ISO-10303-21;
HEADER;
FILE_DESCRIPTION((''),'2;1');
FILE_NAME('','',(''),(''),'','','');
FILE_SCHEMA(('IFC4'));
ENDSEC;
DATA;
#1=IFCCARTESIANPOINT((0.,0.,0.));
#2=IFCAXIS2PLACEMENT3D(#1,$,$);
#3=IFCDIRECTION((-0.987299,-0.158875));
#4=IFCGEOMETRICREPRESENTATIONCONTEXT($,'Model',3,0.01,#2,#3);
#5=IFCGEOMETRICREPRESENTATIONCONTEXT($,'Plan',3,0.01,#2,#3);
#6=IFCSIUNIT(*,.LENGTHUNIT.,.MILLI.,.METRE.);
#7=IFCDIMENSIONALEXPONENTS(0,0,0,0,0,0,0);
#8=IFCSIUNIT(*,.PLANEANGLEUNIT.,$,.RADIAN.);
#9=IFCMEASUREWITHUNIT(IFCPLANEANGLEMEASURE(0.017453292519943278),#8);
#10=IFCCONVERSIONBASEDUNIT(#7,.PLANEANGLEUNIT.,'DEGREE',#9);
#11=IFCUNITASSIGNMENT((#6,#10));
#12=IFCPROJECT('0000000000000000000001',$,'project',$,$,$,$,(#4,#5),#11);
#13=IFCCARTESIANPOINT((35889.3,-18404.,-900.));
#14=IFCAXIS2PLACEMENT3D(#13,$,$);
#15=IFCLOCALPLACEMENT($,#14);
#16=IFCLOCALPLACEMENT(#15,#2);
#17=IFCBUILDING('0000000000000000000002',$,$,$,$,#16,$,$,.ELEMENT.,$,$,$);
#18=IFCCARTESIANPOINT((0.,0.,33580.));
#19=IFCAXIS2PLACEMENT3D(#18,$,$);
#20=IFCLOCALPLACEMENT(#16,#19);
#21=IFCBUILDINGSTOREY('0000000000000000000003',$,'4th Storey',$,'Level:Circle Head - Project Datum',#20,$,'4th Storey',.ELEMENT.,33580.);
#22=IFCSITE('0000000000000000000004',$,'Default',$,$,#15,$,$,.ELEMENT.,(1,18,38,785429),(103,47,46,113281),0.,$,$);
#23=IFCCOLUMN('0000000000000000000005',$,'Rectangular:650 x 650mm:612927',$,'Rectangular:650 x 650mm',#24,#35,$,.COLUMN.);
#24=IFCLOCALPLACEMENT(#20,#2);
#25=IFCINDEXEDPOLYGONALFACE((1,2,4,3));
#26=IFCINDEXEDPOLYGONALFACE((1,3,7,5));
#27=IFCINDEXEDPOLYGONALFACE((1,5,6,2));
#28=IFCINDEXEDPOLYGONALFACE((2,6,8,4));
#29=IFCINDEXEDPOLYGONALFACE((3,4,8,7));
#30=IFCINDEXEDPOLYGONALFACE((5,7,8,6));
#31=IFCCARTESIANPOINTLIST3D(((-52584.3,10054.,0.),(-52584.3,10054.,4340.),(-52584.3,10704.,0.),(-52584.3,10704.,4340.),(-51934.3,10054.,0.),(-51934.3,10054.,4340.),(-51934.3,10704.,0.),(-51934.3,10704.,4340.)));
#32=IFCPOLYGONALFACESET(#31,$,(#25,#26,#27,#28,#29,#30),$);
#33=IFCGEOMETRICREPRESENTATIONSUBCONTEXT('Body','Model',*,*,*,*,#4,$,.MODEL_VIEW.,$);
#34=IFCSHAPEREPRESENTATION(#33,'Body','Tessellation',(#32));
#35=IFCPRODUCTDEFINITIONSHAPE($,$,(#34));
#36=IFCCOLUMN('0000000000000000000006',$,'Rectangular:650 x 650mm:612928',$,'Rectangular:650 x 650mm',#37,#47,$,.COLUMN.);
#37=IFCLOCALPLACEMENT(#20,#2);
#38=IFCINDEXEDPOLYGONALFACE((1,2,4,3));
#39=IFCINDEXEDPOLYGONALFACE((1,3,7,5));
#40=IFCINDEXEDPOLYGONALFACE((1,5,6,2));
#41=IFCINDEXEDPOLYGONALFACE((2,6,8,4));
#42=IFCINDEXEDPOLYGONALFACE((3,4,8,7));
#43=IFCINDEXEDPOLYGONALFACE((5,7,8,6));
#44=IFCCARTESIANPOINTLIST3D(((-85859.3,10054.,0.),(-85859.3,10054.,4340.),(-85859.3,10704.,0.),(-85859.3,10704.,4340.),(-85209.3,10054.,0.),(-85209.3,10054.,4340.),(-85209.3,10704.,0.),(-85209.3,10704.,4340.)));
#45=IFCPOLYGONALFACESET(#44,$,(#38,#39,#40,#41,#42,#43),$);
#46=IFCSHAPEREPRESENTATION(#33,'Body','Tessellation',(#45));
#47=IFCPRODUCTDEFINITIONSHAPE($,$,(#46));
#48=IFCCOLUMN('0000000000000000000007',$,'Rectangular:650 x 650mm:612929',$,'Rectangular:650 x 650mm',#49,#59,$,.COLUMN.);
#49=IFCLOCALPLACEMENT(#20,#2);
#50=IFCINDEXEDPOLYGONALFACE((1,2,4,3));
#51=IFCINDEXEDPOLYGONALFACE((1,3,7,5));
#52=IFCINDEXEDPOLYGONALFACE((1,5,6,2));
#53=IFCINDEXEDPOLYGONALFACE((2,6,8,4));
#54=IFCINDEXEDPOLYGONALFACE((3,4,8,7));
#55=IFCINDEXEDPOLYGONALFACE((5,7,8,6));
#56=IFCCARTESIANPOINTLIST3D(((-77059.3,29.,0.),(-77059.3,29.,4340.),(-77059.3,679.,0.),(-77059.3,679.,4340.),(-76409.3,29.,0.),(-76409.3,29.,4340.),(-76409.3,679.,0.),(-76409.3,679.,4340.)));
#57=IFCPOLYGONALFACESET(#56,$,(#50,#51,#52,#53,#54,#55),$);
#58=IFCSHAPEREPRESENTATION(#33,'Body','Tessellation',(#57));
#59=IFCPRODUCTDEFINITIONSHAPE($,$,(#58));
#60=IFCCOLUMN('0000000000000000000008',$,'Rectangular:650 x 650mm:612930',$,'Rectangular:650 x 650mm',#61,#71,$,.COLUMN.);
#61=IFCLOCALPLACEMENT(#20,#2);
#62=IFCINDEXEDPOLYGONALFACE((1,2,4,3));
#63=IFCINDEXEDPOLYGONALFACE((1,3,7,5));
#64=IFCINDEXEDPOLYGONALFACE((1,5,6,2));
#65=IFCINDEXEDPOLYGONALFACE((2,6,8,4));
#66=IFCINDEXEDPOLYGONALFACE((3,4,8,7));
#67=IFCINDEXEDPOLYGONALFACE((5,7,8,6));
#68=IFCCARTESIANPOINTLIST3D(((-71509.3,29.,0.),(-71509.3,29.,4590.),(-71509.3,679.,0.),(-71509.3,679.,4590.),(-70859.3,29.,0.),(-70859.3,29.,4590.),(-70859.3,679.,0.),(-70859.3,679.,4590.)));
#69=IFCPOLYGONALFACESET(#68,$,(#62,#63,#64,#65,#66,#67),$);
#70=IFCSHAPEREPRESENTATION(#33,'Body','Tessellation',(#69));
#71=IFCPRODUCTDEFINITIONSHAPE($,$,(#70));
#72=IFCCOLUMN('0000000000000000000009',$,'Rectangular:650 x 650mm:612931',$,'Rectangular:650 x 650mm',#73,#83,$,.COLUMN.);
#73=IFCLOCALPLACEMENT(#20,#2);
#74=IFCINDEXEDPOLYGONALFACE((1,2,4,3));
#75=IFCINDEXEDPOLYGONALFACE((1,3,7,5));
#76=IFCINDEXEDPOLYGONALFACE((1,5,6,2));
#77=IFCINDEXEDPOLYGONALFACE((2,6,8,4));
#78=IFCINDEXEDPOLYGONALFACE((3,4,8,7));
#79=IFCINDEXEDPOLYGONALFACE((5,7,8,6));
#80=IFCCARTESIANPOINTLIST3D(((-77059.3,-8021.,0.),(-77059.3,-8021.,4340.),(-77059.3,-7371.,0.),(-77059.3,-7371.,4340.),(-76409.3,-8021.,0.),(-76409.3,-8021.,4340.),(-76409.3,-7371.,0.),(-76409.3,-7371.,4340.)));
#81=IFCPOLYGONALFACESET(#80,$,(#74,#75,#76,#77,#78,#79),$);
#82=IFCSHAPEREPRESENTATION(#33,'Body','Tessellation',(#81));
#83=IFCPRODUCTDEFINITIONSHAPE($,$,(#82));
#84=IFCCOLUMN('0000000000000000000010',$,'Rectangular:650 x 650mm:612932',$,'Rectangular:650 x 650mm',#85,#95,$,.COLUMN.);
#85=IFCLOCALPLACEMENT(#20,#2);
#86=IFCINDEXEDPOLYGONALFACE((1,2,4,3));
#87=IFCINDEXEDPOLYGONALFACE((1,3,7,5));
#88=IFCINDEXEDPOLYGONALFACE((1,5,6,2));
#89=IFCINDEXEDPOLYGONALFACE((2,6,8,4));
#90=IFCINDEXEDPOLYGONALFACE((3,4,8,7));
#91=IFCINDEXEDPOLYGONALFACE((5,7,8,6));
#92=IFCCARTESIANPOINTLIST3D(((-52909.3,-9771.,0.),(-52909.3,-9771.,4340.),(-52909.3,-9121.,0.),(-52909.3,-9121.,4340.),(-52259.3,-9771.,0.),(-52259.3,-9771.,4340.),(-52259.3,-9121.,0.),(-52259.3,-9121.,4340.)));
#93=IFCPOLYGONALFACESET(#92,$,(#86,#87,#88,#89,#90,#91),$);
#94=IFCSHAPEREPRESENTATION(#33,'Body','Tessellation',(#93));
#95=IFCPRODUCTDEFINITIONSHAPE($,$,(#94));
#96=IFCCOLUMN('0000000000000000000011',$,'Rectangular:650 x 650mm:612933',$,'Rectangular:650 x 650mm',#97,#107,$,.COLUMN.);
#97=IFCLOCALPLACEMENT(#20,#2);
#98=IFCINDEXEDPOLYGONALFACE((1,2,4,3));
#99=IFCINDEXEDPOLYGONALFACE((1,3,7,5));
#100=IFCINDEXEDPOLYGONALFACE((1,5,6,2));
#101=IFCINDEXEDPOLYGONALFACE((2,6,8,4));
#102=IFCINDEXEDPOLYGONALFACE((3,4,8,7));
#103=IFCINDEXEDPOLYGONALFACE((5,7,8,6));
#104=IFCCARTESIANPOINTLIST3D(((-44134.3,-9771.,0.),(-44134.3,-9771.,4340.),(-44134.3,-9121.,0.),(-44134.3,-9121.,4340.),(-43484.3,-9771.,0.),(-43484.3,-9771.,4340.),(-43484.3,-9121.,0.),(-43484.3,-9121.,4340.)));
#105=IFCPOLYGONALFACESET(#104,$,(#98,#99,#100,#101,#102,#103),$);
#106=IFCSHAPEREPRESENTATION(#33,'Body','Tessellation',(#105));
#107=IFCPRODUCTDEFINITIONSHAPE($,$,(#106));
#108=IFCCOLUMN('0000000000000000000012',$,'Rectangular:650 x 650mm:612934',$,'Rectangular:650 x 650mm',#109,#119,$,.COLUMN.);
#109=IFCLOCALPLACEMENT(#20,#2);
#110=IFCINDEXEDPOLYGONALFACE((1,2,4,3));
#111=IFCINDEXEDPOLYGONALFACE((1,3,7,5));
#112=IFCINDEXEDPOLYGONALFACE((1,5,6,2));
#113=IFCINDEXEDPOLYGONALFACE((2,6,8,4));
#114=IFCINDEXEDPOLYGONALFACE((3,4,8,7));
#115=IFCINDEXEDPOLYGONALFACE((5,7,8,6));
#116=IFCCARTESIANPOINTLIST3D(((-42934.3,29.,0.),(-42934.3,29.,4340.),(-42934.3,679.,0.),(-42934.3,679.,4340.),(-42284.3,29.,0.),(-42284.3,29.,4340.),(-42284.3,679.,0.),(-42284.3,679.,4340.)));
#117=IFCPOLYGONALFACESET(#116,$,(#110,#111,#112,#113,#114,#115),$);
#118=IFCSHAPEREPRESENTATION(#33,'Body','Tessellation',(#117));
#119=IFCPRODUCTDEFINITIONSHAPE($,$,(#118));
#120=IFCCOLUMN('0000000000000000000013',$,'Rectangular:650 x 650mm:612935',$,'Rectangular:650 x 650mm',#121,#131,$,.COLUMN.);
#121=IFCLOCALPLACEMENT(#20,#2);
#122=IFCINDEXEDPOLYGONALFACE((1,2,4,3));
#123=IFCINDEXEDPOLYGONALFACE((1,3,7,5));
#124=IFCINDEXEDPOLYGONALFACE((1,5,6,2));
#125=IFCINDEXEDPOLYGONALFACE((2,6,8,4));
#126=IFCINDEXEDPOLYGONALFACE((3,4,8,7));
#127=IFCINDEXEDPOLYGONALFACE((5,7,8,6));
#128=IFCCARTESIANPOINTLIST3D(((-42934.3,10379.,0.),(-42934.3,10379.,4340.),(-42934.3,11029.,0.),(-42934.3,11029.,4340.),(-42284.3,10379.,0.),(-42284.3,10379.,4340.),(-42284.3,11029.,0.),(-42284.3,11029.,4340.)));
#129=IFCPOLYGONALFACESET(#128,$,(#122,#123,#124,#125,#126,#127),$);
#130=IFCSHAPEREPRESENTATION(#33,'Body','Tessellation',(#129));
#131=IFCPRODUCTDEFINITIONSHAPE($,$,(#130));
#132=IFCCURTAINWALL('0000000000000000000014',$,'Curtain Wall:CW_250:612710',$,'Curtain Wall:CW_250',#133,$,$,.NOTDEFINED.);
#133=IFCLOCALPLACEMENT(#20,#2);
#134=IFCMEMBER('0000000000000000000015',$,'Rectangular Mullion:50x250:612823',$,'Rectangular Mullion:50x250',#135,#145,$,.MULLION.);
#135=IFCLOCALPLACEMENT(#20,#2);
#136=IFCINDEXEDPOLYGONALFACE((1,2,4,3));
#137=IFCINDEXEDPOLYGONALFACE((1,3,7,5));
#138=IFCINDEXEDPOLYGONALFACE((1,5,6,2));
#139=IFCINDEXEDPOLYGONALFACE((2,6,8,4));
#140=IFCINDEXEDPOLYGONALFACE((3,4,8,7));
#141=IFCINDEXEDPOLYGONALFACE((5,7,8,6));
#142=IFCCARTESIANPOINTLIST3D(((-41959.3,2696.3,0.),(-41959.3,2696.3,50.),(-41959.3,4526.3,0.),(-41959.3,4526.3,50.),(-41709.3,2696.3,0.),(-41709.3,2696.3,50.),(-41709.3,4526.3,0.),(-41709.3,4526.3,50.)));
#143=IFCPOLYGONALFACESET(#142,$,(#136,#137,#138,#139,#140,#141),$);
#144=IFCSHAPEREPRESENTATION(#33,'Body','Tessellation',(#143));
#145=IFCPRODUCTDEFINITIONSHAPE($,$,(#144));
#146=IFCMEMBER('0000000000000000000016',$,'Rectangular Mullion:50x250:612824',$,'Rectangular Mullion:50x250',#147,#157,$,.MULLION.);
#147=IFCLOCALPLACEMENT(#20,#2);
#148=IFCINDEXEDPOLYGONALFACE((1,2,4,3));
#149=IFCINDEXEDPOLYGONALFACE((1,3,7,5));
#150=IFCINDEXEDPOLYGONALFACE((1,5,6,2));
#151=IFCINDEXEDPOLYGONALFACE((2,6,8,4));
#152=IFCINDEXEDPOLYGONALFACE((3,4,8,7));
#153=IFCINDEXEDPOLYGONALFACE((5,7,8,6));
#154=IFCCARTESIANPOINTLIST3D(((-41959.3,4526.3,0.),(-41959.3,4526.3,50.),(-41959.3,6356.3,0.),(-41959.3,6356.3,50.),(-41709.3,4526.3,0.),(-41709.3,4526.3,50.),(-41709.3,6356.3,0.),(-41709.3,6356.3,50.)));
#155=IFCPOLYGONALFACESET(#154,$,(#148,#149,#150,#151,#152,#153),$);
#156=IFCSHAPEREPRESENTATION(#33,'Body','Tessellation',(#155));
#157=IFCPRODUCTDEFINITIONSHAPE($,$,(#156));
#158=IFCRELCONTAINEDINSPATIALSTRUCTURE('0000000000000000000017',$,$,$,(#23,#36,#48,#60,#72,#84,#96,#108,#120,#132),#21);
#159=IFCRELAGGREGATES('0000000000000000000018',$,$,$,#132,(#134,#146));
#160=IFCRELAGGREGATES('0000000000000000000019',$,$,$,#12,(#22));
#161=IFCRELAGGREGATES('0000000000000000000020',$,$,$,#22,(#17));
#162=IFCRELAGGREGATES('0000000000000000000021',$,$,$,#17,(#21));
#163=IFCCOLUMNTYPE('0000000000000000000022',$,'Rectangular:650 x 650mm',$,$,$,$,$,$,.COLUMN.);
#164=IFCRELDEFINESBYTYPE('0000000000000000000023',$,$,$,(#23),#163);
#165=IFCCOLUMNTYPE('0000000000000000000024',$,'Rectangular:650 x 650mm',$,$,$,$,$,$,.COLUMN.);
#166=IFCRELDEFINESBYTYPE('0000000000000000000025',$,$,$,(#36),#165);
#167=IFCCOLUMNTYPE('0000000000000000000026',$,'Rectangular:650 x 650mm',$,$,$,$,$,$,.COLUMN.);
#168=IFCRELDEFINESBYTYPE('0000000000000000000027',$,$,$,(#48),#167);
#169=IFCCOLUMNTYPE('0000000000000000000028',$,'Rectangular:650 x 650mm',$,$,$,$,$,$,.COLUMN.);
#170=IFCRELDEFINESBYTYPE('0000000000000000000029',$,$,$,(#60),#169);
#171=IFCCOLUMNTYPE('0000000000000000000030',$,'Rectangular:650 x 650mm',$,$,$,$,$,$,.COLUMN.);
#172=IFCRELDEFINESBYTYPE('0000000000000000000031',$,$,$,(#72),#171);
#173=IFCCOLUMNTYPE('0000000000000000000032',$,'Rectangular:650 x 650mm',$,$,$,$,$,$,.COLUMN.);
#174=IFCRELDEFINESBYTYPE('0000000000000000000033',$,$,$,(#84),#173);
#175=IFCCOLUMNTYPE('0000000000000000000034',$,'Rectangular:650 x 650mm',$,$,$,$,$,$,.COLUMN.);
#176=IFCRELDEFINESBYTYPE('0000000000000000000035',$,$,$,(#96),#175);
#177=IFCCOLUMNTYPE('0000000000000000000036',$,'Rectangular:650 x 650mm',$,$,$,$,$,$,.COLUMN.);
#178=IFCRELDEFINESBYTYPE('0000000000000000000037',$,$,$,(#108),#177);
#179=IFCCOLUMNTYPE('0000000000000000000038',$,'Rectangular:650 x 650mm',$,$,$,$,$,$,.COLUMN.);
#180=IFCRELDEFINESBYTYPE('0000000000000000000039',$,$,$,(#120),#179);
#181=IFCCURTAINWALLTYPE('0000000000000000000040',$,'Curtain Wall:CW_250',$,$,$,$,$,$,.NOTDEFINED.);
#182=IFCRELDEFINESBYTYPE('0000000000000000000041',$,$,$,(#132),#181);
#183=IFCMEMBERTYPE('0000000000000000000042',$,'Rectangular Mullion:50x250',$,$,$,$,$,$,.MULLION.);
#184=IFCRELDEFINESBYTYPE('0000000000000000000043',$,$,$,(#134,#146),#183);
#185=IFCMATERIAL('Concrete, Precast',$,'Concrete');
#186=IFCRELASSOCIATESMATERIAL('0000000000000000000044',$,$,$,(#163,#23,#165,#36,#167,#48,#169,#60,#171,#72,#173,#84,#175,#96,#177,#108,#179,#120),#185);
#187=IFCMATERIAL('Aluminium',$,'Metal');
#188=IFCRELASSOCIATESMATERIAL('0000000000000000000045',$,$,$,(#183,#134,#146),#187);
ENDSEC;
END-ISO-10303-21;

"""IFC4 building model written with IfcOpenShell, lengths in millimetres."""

from ifc_helpers import new_model, entity, si_unit, converted_unit, direction, frame, origin, place, context, subcontext, project, spatial, indexed_curve, outline, extrude, source, transform, mapped, material, type_object, type_shapes, element, aggregate, save


model = new_model("IFC4")

# Units and contexts
model_context = context("Model", 3, precision=0.01, world=origin(), true_north=direction((-0.987299, -0.158875)))
plan_context = context("Plan", 3, precision=0.01, world=origin(), true_north=direction((-0.987299, -0.158875)))
body_context = subcontext(model_context, "Body", "Model", "MODEL_VIEW")
ifc_project = project(units=[si_unit("LENGTHUNIT", "METRE", prefix="MILLI"), converted_unit("PLANEANGLEUNIT", "DEGREE", entity("IfcPlaneAngleMeasure", 0.017453292519943278), si_unit("PLANEANGLEUNIT", "RADIAN"), dimensions=[0, 0, 0, 0, 0, 0, 0])], contexts=[model_context, plan_context])

# Site, building, storey
site_placement = place(None, frame((35889.3, -18404.0, -900.0)))
site = spatial("IfcSite", under=ifc_project, at=site_placement, Name="Default", CompositionType="ELEMENT", RefLatitude=(1, 18, 38, 785429), RefLongitude=(103, 47, 46, 113281), RefElevation=0.0)
building_placement = place(site_placement, origin())
building = spatial("IfcBuilding", under=site, at=building_placement, CompositionType="ELEMENT")
storey_placement = place(building_placement, frame((0.0, 0.0, 33580.0)))
storey = spatial("IfcBuildingStorey", under=building, at=storey_placement, Name="4th Storey", ObjectType="Level:Circle Head - Project Datum", LongName="4th Storey", CompositionType="ELEMENT", Elevation=33580.0)

# Columns
ifc_material_1 = material(Name="Concrete, Precast", Category="Concrete")
column_type_1 = type_object("IfcColumnType", Name="Rectangular:650 x 650mm", PredefinedType="COLUMN", material=ifc_material_1)
shared_shape_1 = source(origin(), body_context, "Body", "SweptSolid", [
    extrude(outline(indexed_curve([(-325.0, -325.0), (325.0, -325.0), (325.0, 325.0), (-325.0, 325.0), (-325.0, -325.0)], self_intersect=False)), frame((-52259.3, 10379.0, 33580.0), z_axis=(0.0, 0.0, 1.0), x_axis=(0.0, -1.0, 0.0)), (0.0, 0.0, 1.0), 4340.0),
])
type_shapes(column_type_1, [shared_shape_1])
column_1_placement = place(storey_placement, frame((0.0, 0.0, -33580.0)))
element("IfcColumn", 1, at=column_1_placement, inside=storey, type_object=column_type_1, material=ifc_material_1, Name="Rectangular:650 x 650mm:612927", ObjectType="Rectangular:650 x 650mm", PredefinedType="COLUMN", context=body_context, shape_type="MappedRepresentation", body=[
    mapped(shared_shape_1, transform((0.0, 0.0, 0.0), scale=1.0)),
])
column_type_2 = type_object("IfcColumnType", Name="Rectangular:650 x 650mm", PredefinedType="COLUMN", material=ifc_material_1)
shared_shape_2 = source(origin(), body_context, "Body", "SweptSolid", [
    extrude(outline(indexed_curve([(-325.0, -325.0), (325.0, -325.0), (325.0, 325.0), (-325.0, 325.0), (-325.0, -325.0)], self_intersect=False)), frame((-85534.3, 10379.0, 33580.0), z_axis=(0.0, 0.0, 1.0), x_axis=(0.0, 1.0, 0.0)), (0.0, 0.0, 1.0), 4340.0),
])
type_shapes(column_type_2, [shared_shape_2])
column_2_placement = place(storey_placement, frame((0.0, 0.0, -33580.0)))
element("IfcColumn", 2, at=column_2_placement, inside=storey, type_object=column_type_2, material=ifc_material_1, Name="Rectangular:650 x 650mm:612928", ObjectType="Rectangular:650 x 650mm", PredefinedType="COLUMN", context=body_context, shape_type="MappedRepresentation", body=[
    mapped(shared_shape_2, transform((0.0, 0.0, 0.0), scale=1.0)),
])
column_type_3 = type_object("IfcColumnType", Name="Rectangular:650 x 650mm", PredefinedType="COLUMN", material=ifc_material_1)
shared_shape_3 = source(origin(), body_context, "Body", "SweptSolid", [
    extrude(outline(indexed_curve([(-325.0, -325.0), (325.0, -325.0), (325.0, 325.0), (-325.0, 325.0), (-325.0, -325.0)], self_intersect=False)), frame((-76734.3, 354.0, 33580.0), z_axis=(0.0, 0.0, 1.0), x_axis=(-1.0, 0.0, 0.0)), (0.0, 0.0, 1.0), 4340.0),
])
type_shapes(column_type_3, [shared_shape_3])
column_3_placement = place(storey_placement, frame((0.0, 0.0, -33580.0)))
element("IfcColumn", 3, at=column_3_placement, inside=storey, type_object=column_type_3, material=ifc_material_1, Name="Rectangular:650 x 650mm:612929", ObjectType="Rectangular:650 x 650mm", PredefinedType="COLUMN", context=body_context, shape_type="MappedRepresentation", body=[
    mapped(shared_shape_3, transform((0.0, 0.0, 0.0), scale=1.0)),
])
column_type_4 = type_object("IfcColumnType", Name="Rectangular:650 x 650mm", PredefinedType="COLUMN", material=ifc_material_1)
shared_shape_4 = source(origin(), body_context, "Body", "SweptSolid", [
    extrude(outline(indexed_curve([(-325.0, -325.0), (325.0, -325.0), (325.0, 325.0), (-325.0, 325.0), (-325.0, -325.0)], self_intersect=False)), frame((-71184.3, 354.0, 33580.0), z_axis=(0.0, 0.0, 1.0), x_axis=(-1.0, 0.0, 0.0)), (0.0, 0.0, 1.0), 4590.0),
])
type_shapes(column_type_4, [shared_shape_4])
column_4_placement = place(storey_placement, frame((0.0, 0.0, -33580.0)))
element("IfcColumn", 4, at=column_4_placement, inside=storey, type_object=column_type_4, material=ifc_material_1, Name="Rectangular:650 x 650mm:612930", ObjectType="Rectangular:650 x 650mm", PredefinedType="COLUMN", context=body_context, shape_type="MappedRepresentation", body=[
    mapped(shared_shape_4, transform((0.0, 0.0, 0.0), scale=1.0)),
])
column_type_5 = type_object("IfcColumnType", Name="Rectangular:650 x 650mm", PredefinedType="COLUMN", material=ifc_material_1)
shared_shape_5 = source(origin(), body_context, "Body", "SweptSolid", [
    extrude(outline(indexed_curve([(-325.0, -325.0), (325.0, -325.0), (325.0, 325.0), (-325.0, 325.0), (-325.0, -325.0)], self_intersect=False)), frame((-76734.3, -7696.0, 33580.0), z_axis=(0.0, 0.0, 1.0), x_axis=(0.0, -1.0, 0.0)), (0.0, 0.0, 1.0), 4340.0),
])
type_shapes(column_type_5, [shared_shape_5])
column_5_placement = place(storey_placement, frame((0.0, 0.0, -33580.0)))
element("IfcColumn", 5, at=column_5_placement, inside=storey, type_object=column_type_5, material=ifc_material_1, Name="Rectangular:650 x 650mm:612931", ObjectType="Rectangular:650 x 650mm", PredefinedType="COLUMN", context=body_context, shape_type="MappedRepresentation", body=[
    mapped(shared_shape_5, transform((0.0, 0.0, 0.0), scale=1.0)),
])
column_type_6 = type_object("IfcColumnType", Name="Rectangular:650 x 650mm", PredefinedType="COLUMN", material=ifc_material_1)
shared_shape_6 = source(origin(), body_context, "Body", "SweptSolid", [
    extrude(outline(indexed_curve([(-325.0, -325.0), (325.0, -325.0), (325.0, 325.0), (-325.0, 325.0), (-325.0, -325.0)], self_intersect=False)), frame((-52584.3, -9446.0, 33580.0), z_axis=(0.0, 0.0, 1.0), x_axis=(-1.0, 0.0, 0.0)), (0.0, 0.0, 1.0), 4340.0),
])
type_shapes(column_type_6, [shared_shape_6])
column_6_placement = place(storey_placement, frame((0.0, 0.0, -33580.0)))
element("IfcColumn", 6, at=column_6_placement, inside=storey, type_object=column_type_6, material=ifc_material_1, Name="Rectangular:650 x 650mm:612932", ObjectType="Rectangular:650 x 650mm", PredefinedType="COLUMN", context=body_context, shape_type="MappedRepresentation", body=[
    mapped(shared_shape_6, transform((0.0, 0.0, 0.0), scale=1.0)),
])
column_type_7 = type_object("IfcColumnType", Name="Rectangular:650 x 650mm", PredefinedType="COLUMN", material=ifc_material_1)
shared_shape_7 = source(origin(), body_context, "Body", "SweptSolid", [
    extrude(outline(indexed_curve([(-325.0, -325.0), (325.0, -325.0), (325.0, 325.0), (-325.0, 325.0), (-325.0, -325.0)], self_intersect=False)), frame((-43809.3, -9446.0, 33580.0), z_axis=(0.0, 0.0, 1.0), x_axis=(-1.0, 0.0, 0.0)), (0.0, 0.0, 1.0), 4340.0),
])
type_shapes(column_type_7, [shared_shape_7])
column_7_placement = place(storey_placement, frame((0.0, 0.0, -33580.0)))
element("IfcColumn", 7, at=column_7_placement, inside=storey, type_object=column_type_7, material=ifc_material_1, Name="Rectangular:650 x 650mm:612933", ObjectType="Rectangular:650 x 650mm", PredefinedType="COLUMN", context=body_context, shape_type="MappedRepresentation", body=[
    mapped(shared_shape_7, transform((0.0, 0.0, 0.0), scale=1.0)),
])
column_type_8 = type_object("IfcColumnType", Name="Rectangular:650 x 650mm", PredefinedType="COLUMN", material=ifc_material_1)
shared_shape_8 = source(origin(), body_context, "Body", "SweptSolid", [
    extrude(outline(indexed_curve([(-325.0, -325.0), (325.0, -325.0), (325.0, 325.0), (-325.0, 325.0), (-325.0, -325.0)], self_intersect=False)), frame((-42609.3, 354.0, 33580.0), z_axis=(0.0, 0.0, 1.0), x_axis=(0.0, -1.0, 0.0)), (0.0, 0.0, 1.0), 4340.0),
])
type_shapes(column_type_8, [shared_shape_8])
column_8_placement = place(storey_placement, frame((0.0, 0.0, -33580.0)))
element("IfcColumn", 8, at=column_8_placement, inside=storey, type_object=column_type_8, material=ifc_material_1, Name="Rectangular:650 x 650mm:612934", ObjectType="Rectangular:650 x 650mm", PredefinedType="COLUMN", context=body_context, shape_type="MappedRepresentation", body=[
    mapped(shared_shape_8, transform((0.0, 0.0, 0.0), scale=1.0)),
])
column_type_9 = type_object("IfcColumnType", Name="Rectangular:650 x 650mm", PredefinedType="COLUMN", material=ifc_material_1)
shared_shape_9 = source(origin(), body_context, "Body", "SweptSolid", [
    extrude(outline(indexed_curve([(-325.0, -325.0), (325.0, -325.0), (325.0, 325.0), (-325.0, 325.0), (-325.0, -325.0)], self_intersect=False)), frame((-42609.3, 10704.0, 33580.0), z_axis=(0.0, 0.0, 1.0), x_axis=(0.0, -1.0, 0.0)), (0.0, 0.0, 1.0), 4340.0),
])
type_shapes(column_type_9, [shared_shape_9])
column_9_placement = place(storey_placement, frame((0.0, 0.0, -33580.0)))
element("IfcColumn", 9, at=column_9_placement, inside=storey, type_object=column_type_9, material=ifc_material_1, Name="Rectangular:650 x 650mm:612935", ObjectType="Rectangular:650 x 650mm", PredefinedType="COLUMN", context=body_context, shape_type="MappedRepresentation", body=[
    mapped(shared_shape_9, transform((0.0, 0.0, 0.0), scale=1.0)),
])

# Curtain wall, members
curtain_wall_type = type_object("IfcCurtainWallType", Name="Curtain Wall:CW_250", PredefinedType="NOTDEFINED")
curtain_wall_1_placement = place(storey_placement, frame((0.0, 0.0, -33580.0)))
curtain_wall_1 = element("IfcCurtainWall", 10, at=curtain_wall_1_placement, inside=storey, type_object=curtain_wall_type, Name="Curtain Wall:CW_250:612710", ObjectType="Curtain Wall:CW_250", PredefinedType="NOTDEFINED")
ifc_material_2 = material(Name="Aluminium", Category="Metal")
member_type_1 = type_object("IfcMemberType", Name="Rectangular Mullion:50x250", PredefinedType="MULLION", material=ifc_material_2)
shared_shape_10 = source(origin(), body_context, "Body", "SweptSolid", [
    extrude(outline(indexed_curve([(-25.0, -125.0), (25.0, -125.0), (25.0, 125.0), (-25.0, 125.0), (-25.0, -125.0)], self_intersect=False)), frame((-25.0, -125.0, -1830.0), z_axis=(0.0, 0.0, 1.0), x_axis=(-1.0, 0.0, 0.0)), (0.0, 0.0, 1.0), 1830.0),
])
type_shapes(member_type_1, [shared_shape_10])
member_1_placement = place(curtain_wall_1_placement, frame((-41709.3, 2696.3, 33580.0), z_axis=(0.0, -1.0, 0.0), x_axis=(0.0, 0.0, -1.0)))
member_1 = element("IfcMember", 11, at=member_1_placement, type_object=member_type_1, material=ifc_material_2, Name="Rectangular Mullion:50x250:612823", ObjectType="Rectangular Mullion:50x250", PredefinedType="MULLION", context=body_context, shape_type="MappedRepresentation", body=[
    mapped(shared_shape_10, transform((0.0, 0.0, 0.0), scale=1.0)),
])
member_2_placement = place(curtain_wall_1_placement, frame((-41709.3, 4526.3, 33580.0), z_axis=(0.0, -1.0, 0.0), x_axis=(0.0, 0.0, -1.0)))
member_2 = element("IfcMember", 12, at=member_2_placement, type_object=member_type_1, material=ifc_material_2, Name="Rectangular Mullion:50x250:612824", ObjectType="Rectangular Mullion:50x250", PredefinedType="MULLION", context=body_context, shape_type="MappedRepresentation", body=[
    mapped(shared_shape_10, transform((0.0, 0.0, 0.0), scale=1.0)),
])
aggregate(curtain_wall_1, [member_1, member_2])

save(model, "model.ifc")
